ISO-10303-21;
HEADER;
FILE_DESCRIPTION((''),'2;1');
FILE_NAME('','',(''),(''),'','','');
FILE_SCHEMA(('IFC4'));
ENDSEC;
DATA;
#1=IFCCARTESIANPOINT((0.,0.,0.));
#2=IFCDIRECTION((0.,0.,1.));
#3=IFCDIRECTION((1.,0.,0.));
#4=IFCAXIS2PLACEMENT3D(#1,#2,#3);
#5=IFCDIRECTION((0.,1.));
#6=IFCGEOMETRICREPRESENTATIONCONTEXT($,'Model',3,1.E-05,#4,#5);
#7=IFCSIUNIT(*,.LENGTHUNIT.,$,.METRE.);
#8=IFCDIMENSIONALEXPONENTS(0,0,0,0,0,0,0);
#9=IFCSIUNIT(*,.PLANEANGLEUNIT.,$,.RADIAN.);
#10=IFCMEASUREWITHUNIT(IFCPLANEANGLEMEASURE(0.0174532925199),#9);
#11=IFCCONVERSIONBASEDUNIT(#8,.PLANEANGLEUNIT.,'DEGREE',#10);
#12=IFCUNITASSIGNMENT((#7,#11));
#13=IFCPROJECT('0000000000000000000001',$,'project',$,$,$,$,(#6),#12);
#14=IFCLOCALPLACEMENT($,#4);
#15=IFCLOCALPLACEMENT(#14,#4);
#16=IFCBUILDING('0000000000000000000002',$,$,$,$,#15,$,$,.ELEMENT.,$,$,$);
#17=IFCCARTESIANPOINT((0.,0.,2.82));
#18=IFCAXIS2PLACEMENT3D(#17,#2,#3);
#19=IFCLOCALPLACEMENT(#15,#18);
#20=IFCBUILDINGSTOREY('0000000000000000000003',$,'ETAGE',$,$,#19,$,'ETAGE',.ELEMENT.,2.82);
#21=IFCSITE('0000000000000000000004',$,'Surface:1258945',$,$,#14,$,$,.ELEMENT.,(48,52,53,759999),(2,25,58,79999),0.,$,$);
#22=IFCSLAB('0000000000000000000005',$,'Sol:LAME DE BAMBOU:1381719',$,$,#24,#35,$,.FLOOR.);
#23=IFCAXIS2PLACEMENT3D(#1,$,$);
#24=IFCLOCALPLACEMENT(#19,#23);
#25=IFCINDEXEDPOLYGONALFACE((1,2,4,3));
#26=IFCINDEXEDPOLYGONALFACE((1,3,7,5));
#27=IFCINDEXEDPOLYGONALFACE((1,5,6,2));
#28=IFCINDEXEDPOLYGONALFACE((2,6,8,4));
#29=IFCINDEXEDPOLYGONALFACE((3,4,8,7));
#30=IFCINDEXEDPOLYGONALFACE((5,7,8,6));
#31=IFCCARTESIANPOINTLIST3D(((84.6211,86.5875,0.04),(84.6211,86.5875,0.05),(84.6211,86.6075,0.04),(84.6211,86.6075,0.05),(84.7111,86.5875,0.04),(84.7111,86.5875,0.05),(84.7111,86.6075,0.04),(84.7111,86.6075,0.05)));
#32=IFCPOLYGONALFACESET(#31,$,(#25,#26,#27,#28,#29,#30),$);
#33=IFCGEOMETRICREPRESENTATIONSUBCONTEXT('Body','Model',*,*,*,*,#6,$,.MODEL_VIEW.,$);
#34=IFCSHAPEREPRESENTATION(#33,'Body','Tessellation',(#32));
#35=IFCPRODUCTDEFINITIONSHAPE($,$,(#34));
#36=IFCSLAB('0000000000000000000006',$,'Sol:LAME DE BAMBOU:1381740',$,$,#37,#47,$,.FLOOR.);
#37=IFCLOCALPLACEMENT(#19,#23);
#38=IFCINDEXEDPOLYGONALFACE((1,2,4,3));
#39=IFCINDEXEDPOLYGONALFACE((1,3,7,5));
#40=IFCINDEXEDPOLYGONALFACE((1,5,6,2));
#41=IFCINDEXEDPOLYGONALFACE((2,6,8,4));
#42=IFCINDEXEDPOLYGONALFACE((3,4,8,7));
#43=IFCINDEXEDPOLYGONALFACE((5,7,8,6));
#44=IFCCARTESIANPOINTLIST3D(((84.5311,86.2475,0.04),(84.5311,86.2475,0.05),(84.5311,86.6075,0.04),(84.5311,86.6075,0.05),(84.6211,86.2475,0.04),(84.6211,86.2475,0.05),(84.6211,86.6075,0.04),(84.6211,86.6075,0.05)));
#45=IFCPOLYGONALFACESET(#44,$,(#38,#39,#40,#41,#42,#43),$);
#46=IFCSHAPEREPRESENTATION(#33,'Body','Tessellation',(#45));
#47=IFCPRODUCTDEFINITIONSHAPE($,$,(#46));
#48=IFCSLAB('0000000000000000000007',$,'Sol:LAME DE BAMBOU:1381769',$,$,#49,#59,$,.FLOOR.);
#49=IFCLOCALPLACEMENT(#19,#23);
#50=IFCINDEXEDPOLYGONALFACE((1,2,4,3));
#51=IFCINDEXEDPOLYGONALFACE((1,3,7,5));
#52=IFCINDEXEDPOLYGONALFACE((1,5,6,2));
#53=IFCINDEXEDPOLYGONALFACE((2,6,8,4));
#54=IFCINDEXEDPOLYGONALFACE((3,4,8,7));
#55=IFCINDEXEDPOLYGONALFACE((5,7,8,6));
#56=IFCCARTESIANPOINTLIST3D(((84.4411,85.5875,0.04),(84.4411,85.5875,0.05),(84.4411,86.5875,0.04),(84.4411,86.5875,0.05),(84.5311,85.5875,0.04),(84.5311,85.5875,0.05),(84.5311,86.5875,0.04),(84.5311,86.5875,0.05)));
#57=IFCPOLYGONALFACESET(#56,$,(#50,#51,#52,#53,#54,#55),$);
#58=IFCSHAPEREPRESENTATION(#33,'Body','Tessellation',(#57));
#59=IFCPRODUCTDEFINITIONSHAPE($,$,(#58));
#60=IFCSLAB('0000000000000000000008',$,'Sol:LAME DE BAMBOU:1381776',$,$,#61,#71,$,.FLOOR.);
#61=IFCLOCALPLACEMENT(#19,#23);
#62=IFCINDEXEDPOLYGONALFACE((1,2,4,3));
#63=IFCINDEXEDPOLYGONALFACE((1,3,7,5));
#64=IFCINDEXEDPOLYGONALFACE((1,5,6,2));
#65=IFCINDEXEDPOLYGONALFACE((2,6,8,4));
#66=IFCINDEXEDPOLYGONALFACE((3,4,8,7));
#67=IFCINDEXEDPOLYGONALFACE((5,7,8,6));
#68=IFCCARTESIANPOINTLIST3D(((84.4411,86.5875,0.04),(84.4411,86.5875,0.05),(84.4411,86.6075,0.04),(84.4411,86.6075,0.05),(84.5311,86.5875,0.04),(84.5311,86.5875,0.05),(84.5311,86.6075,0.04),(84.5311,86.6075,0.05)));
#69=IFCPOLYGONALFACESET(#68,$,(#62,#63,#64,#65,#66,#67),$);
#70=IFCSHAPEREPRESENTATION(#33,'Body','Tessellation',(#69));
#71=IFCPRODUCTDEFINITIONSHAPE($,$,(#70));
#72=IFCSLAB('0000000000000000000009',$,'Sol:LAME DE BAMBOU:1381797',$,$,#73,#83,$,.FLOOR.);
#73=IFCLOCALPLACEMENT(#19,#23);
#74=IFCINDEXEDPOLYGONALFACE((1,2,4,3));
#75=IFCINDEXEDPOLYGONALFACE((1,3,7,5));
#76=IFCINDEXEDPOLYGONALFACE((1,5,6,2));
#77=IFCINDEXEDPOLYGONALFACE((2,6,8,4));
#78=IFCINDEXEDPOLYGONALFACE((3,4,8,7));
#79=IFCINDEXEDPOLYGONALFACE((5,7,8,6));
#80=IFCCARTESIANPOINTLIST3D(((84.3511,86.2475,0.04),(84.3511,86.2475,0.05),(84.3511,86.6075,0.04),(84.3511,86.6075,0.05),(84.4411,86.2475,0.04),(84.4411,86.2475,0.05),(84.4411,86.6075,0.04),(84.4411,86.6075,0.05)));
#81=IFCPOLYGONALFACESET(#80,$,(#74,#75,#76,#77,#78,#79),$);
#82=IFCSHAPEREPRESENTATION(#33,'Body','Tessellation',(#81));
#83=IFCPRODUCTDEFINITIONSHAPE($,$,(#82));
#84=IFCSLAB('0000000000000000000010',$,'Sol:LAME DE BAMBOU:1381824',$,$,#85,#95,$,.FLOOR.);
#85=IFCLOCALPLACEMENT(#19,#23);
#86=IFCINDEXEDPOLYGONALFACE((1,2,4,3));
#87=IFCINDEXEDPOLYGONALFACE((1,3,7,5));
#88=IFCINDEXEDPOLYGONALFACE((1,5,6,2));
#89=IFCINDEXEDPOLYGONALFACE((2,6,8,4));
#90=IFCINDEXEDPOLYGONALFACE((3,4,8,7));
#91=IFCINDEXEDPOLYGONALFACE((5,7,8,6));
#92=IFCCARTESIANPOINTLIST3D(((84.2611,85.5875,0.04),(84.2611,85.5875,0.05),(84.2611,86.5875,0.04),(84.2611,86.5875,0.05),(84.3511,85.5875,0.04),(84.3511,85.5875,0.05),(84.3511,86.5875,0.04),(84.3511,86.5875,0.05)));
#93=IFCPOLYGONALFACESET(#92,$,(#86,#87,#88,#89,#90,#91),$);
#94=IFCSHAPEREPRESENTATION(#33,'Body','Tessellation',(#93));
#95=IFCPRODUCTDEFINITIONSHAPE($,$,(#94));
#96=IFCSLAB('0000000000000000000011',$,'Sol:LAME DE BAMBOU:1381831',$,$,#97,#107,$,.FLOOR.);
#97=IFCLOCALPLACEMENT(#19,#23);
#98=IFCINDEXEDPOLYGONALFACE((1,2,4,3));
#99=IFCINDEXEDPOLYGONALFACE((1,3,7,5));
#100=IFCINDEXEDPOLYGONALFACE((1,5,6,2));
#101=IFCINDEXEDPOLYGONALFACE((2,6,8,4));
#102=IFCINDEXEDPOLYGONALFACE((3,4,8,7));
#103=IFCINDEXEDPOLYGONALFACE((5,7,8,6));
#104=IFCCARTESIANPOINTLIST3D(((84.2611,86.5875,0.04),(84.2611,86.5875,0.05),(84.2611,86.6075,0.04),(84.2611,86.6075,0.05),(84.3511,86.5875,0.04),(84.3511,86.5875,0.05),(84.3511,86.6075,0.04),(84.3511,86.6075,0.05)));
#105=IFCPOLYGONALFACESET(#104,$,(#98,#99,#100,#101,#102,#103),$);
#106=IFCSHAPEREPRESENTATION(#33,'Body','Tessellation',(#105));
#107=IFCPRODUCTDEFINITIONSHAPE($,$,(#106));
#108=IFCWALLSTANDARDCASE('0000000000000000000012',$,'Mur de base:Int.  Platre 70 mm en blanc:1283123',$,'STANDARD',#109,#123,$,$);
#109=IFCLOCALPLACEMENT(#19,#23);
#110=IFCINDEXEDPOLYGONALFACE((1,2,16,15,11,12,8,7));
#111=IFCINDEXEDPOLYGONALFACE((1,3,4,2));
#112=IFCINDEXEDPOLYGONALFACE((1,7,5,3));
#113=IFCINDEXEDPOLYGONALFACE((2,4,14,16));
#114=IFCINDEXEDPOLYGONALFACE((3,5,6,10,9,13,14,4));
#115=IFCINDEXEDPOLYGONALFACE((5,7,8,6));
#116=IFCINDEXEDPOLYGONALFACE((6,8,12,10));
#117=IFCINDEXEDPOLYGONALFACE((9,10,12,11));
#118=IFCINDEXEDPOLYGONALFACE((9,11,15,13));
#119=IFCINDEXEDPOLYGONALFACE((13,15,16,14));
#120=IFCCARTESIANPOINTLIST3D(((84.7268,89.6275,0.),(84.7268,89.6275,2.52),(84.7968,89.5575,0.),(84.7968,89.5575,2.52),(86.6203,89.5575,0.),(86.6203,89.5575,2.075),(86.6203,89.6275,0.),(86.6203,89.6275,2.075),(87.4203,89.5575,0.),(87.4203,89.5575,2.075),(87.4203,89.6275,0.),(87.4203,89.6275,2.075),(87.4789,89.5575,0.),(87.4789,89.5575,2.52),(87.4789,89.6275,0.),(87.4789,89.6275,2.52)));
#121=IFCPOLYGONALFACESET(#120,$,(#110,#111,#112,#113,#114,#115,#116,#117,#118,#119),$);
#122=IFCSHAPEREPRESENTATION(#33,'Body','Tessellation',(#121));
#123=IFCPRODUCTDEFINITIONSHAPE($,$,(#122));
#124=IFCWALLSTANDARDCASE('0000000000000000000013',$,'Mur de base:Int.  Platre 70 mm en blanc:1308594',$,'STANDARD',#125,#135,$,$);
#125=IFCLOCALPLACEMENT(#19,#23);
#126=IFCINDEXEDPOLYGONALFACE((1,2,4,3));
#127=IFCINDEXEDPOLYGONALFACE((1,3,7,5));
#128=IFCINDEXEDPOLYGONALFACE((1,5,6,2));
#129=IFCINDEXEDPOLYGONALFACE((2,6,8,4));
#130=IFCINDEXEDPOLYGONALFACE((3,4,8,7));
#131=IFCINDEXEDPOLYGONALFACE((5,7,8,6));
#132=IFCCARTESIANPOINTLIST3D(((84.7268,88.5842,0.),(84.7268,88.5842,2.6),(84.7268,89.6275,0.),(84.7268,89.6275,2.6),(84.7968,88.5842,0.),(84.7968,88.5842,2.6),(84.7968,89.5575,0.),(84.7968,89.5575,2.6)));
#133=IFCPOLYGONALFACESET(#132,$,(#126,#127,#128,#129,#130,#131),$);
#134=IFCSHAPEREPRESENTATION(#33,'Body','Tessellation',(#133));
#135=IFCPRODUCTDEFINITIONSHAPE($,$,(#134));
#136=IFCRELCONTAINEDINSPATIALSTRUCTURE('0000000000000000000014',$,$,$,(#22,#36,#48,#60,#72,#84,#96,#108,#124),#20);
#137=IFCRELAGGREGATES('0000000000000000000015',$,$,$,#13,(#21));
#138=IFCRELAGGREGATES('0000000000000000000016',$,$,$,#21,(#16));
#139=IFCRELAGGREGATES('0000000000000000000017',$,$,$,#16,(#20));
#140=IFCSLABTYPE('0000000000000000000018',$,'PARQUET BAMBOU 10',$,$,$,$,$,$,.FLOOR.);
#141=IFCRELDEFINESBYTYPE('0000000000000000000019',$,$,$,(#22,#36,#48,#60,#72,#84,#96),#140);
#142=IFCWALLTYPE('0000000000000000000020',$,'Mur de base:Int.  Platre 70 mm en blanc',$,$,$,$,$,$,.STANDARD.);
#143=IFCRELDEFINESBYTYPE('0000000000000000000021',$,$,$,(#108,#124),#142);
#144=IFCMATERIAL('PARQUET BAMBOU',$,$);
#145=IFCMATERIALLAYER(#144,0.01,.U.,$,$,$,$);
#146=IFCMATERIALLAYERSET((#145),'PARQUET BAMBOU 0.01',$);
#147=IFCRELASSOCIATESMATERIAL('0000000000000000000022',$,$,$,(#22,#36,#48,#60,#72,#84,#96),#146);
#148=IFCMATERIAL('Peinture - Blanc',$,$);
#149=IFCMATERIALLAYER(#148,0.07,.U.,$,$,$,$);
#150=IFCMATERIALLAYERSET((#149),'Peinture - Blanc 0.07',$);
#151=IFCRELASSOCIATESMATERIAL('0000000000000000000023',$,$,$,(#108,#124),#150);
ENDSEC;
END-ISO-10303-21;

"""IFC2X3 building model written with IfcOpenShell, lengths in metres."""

from ifc_helpers import new_model, entity, si_unit, converted_unit, direction, frame, origin_with_axes, place, context, subcontext, project, spatial, polyline, outline, extrude, material, layer, layer_set, layer_usage, type_object, element, save


model = new_model("IFC2X3")

# Units and contexts
model_context = context("Model", 3, precision=1e-05, world=origin_with_axes(), true_north=direction((0.0, 1.0)))
body_context = subcontext(model_context, "Body", "Model", "MODEL_VIEW")
ifc_project = project(units=[si_unit("LENGTHUNIT", "METRE"), converted_unit("PLANEANGLEUNIT", "DEGREE", entity("IfcPlaneAngleMeasure", 0.0174532925199), si_unit("PLANEANGLEUNIT", "RADIAN"), dimensions=[0, 0, 0, 0, 0, 0, 0])], contexts=[model_context])

# Site, building, storey
site_placement = place(None, origin_with_axes())
site = spatial("IfcSite", under=ifc_project, at=site_placement, Name="Surface:1258945", CompositionType="ELEMENT", RefLatitude=(48, 52, 53, 759999), RefLongitude=(2, 25, 58, 79999), RefElevation=0.0)
building_placement = place(site_placement, origin_with_axes())
building = spatial("IfcBuilding", under=site, at=building_placement, CompositionType="ELEMENT")
storey_placement = place(building_placement, frame((0.0, 0.0, 2.82), z_axis=(0.0, 0.0, 1.0), x_axis=(1.0, 0.0, 0.0)))
storey = spatial("IfcBuildingStorey", under=building, at=storey_placement, Name="ETAGE", LongName="ETAGE", CompositionType="ELEMENT", Elevation=2.82)

# Slabs
ifc_material_1 = material(Name="PARQUET BAMBOU")
ifc_layer_1 = layer(ifc_material_1, 0.01, ventilated="UNKNOWN")
ifc_layer_set_1 = layer_set([ifc_layer_1], Name="PARQUET BAMBOU 0.01")
slab_type = type_object("IfcSlabType", Name="PARQUET BAMBOU 10", PredefinedType="FLOOR")
ifc_layer_usage_1 = layer_usage(ifc_layer_set_1, "AXIS3", "NEGATIVE", 0.01)
slab_1_placement = place(storey_placement, frame((84.6211, 86.6075, 0.05), z_axis=(0.0, 0.0, 1.0), x_axis=(1.0, 0.0, 0.0)))
element("IfcSlab", 1, at=slab_1_placement, inside=storey, type_object=slab_type, material=ifc_layer_usage_1, Name="Sol:LAME DE BAMBOU:1381719", PredefinedType="FLOOR", context=body_context, shape_type="SweptSolid", body=[
    extrude(outline(polyline([(0.0, 0.0), (0.0, -0.02), (0.09, -0.02), (0.09, 0.0), (0.0, 0.0)])), frame((0.0, 0.0, -0.01), z_axis=(0.0, 0.0, 1.0), x_axis=(1.0, 0.0, 0.0)), (0.0, 0.0, 1.0), 0.01),
])
ifc_layer_usage_2 = layer_usage(ifc_layer_set_1, "AXIS3", "NEGATIVE", 0.01)
slab_2_placement = place(storey_placement, frame((84.5311, 86.6075, 0.05), z_axis=(0.0, 0.0, 1.0), x_axis=(1.0, 0.0, 0.0)))
element("IfcSlab", 2, at=slab_2_placement, inside=storey, type_object=slab_type, material=ifc_layer_usage_2, Name="Sol:LAME DE BAMBOU:1381740", PredefinedType="FLOOR", context=body_context, shape_type="SweptSolid", body=[
    extrude(outline(polyline([(0.0, 0.0), (0.0, -0.36), (0.09, -0.36), (0.09, 0.0), (0.0, 0.0)])), frame((0.0, 0.0, -0.01), z_axis=(0.0, 0.0, 1.0), x_axis=(1.0, 0.0, 0.0)), (0.0, 0.0, 1.0), 0.01),
])
ifc_layer_usage_3 = layer_usage(ifc_layer_set_1, "AXIS3", "NEGATIVE", 0.01)
slab_3_placement = place(storey_placement, frame((84.4411, 86.5875, 0.05), z_axis=(0.0, 0.0, 1.0), x_axis=(1.0, 0.0, 0.0)))
element("IfcSlab", 3, at=slab_3_placement, inside=storey, type_object=slab_type, material=ifc_layer_usage_3, Name="Sol:LAME DE BAMBOU:1381769", PredefinedType="FLOOR", context=body_context, shape_type="SweptSolid", body=[
    extrude(outline(polyline([(0.0, 0.0), (0.0, -1.0), (0.09, -1.0), (0.09, 0.0), (0.0, 0.0)])), frame((0.0, 0.0, -0.01), z_axis=(0.0, 0.0, 1.0), x_axis=(1.0, 0.0, 0.0)), (0.0, 0.0, 1.0), 0.01),
])
ifc_layer_usage_4 = layer_usage(ifc_layer_set_1, "AXIS3", "NEGATIVE", 0.01)
slab_4_placement = place(storey_placement, frame((84.4411, 86.6075, 0.05), z_axis=(0.0, 0.0, 1.0), x_axis=(1.0, 0.0, 0.0)))
element("IfcSlab", 4, at=slab_4_placement, inside=storey, type_object=slab_type, material=ifc_layer_usage_4, Name="Sol:LAME DE BAMBOU:1381776", PredefinedType="FLOOR", context=body_context, shape_type="SweptSolid", body=[
    extrude(outline(polyline([(0.0, 0.0), (0.0, -0.02), (0.09, -0.02), (0.09, 0.0), (0.0, 0.0)])), frame((0.0, 0.0, -0.01), z_axis=(0.0, 0.0, 1.0), x_axis=(1.0, 0.0, 0.0)), (0.0, 0.0, 1.0), 0.01),
])
ifc_layer_usage_5 = layer_usage(ifc_layer_set_1, "AXIS3", "NEGATIVE", 0.01)
slab_5_placement = place(storey_placement, frame((84.3511, 86.6075, 0.05), z_axis=(0.0, 0.0, 1.0), x_axis=(1.0, 0.0, 0.0)))
element("IfcSlab", 5, at=slab_5_placement, inside=storey, type_object=slab_type, material=ifc_layer_usage_5, Name="Sol:LAME DE BAMBOU:1381797", PredefinedType="FLOOR", context=body_context, shape_type="SweptSolid", body=[
    extrude(outline(polyline([(0.0, 0.0), (0.0, -0.36), (0.09, -0.36), (0.09, 0.0), (0.0, 0.0)])), frame((0.0, 0.0, -0.01), z_axis=(0.0, 0.0, 1.0), x_axis=(1.0, 0.0, 0.0)), (0.0, 0.0, 1.0), 0.01),
])
ifc_layer_usage_6 = layer_usage(ifc_layer_set_1, "AXIS3", "NEGATIVE", 0.01)
slab_6_placement = place(storey_placement, frame((84.2611, 86.5875, 0.05), z_axis=(0.0, 0.0, 1.0), x_axis=(1.0, 0.0, 0.0)))
element("IfcSlab", 6, at=slab_6_placement, inside=storey, type_object=slab_type, material=ifc_layer_usage_6, Name="Sol:LAME DE BAMBOU:1381824", PredefinedType="FLOOR", context=body_context, shape_type="SweptSolid", body=[
    extrude(outline(polyline([(0.0, 0.0), (0.0, -1.0), (0.09, -1.0), (0.09, 0.0), (0.0, 0.0)])), frame((0.0, 0.0, -0.01), z_axis=(0.0, 0.0, 1.0), x_axis=(1.0, 0.0, 0.0)), (0.0, 0.0, 1.0), 0.01),
])
ifc_layer_usage_7 = layer_usage(ifc_layer_set_1, "AXIS3", "NEGATIVE", 0.01)
slab_7_placement = place(storey_placement, frame((84.2611, 86.6075, 0.05), z_axis=(0.0, 0.0, 1.0), x_axis=(1.0, 0.0, 0.0)))
element("IfcSlab", 7, at=slab_7_placement, inside=storey, type_object=slab_type, material=ifc_layer_usage_7, Name="Sol:LAME DE BAMBOU:1381831", PredefinedType="FLOOR", context=body_context, shape_type="SweptSolid", body=[
    extrude(outline(polyline([(0.0, 0.0), (0.0, -0.02), (0.09, -0.02), (0.09, 0.0), (0.0, 0.0)])), frame((0.0, 0.0, -0.01), z_axis=(0.0, 0.0, 1.0), x_axis=(1.0, 0.0, 0.0)), (0.0, 0.0, 1.0), 0.01),
])

# Wall, opening
ifc_material_2 = material(Name="Peinture - Blanc")
ifc_layer_2 = layer(ifc_material_2, 0.07, ventilated="UNKNOWN")
ifc_layer_set_2 = layer_set([ifc_layer_2], Name="Peinture - Blanc 0.07")
ifc_layer_usage_8 = layer_usage(ifc_layer_set_2, "AXIS2", "POSITIVE", -0.035)
wall_type = type_object("IfcWallType", Name="Mur de base:Int.  Platre 70 mm en blanc", PredefinedType="STANDARD")
wall_1_placement = place(storey_placement, frame((84.7618, 89.5925, 0.0), z_axis=(0.0, 0.0, 1.0), x_axis=(1.0, 0.0, 0.0)))
wall_1 = element("IfcWallStandardCase", 8, at=wall_1_placement, inside=storey, type_object=wall_type, material=ifc_layer_usage_8, Name="Mur de base:Int.  Platre 70 mm en blanc:1283123", ObjectType="STANDARD", context=body_context, shape_type="SweptSolid", body=[
    extrude(outline(polyline([(0.035, -0.035), (2.7171, -0.035), (2.7171, 0.035), (-0.035, 0.035), (0.035, -0.035)])), origin_with_axes(), (0.0, 0.0, 1.0), 2.52),
])
opening_placement = place(wall_1_placement, frame((2.2586, 0.0, 0.0), z_axis=(0.0, 0.0, 1.0), x_axis=(1.0, 0.0, 0.0)))
element("IfcOpeningElement", 9, at=opening_placement, cuts=wall_1, context=body_context, shape_type="SweptSolid", body=[
    extrude(outline(polyline([(0.4, 0.0), (0.4, 2.075), (-0.4, 2.075), (-0.4, 0.0), (0.4, 0.0)])), frame((0.0, -0.035, 0.0), z_axis=(0.0, 1.0, 0.0), x_axis=(-1.0, 0.0, 0.0)), (0.0, 0.0, 1.0), 0.07),
])

# Wall
ifc_layer_usage_9 = layer_usage(ifc_layer_set_2, "AXIS2", "POSITIVE", -0.035)
wall_2_placement = place(storey_placement, frame((84.7618, 88.5492, 0.0), z_axis=(0.0, 0.0, 1.0), x_axis=(0.0, 1.0, 0.0)))
element("IfcWallStandardCase", 10, at=wall_2_placement, inside=storey, type_object=wall_type, material=ifc_layer_usage_9, Name="Mur de base:Int.  Platre 70 mm en blanc:1308594", ObjectType="STANDARD", context=body_context, shape_type="SweptSolid", body=[
    extrude(outline(polyline([(0.035, -0.035), (1.0083, -0.035), (1.0783, 0.035), (0.035, 0.035), (0.035, -0.035)])), origin_with_axes(), (0.0, 0.0, 1.0), 2.6),
])

save(model, "model.ifc")
